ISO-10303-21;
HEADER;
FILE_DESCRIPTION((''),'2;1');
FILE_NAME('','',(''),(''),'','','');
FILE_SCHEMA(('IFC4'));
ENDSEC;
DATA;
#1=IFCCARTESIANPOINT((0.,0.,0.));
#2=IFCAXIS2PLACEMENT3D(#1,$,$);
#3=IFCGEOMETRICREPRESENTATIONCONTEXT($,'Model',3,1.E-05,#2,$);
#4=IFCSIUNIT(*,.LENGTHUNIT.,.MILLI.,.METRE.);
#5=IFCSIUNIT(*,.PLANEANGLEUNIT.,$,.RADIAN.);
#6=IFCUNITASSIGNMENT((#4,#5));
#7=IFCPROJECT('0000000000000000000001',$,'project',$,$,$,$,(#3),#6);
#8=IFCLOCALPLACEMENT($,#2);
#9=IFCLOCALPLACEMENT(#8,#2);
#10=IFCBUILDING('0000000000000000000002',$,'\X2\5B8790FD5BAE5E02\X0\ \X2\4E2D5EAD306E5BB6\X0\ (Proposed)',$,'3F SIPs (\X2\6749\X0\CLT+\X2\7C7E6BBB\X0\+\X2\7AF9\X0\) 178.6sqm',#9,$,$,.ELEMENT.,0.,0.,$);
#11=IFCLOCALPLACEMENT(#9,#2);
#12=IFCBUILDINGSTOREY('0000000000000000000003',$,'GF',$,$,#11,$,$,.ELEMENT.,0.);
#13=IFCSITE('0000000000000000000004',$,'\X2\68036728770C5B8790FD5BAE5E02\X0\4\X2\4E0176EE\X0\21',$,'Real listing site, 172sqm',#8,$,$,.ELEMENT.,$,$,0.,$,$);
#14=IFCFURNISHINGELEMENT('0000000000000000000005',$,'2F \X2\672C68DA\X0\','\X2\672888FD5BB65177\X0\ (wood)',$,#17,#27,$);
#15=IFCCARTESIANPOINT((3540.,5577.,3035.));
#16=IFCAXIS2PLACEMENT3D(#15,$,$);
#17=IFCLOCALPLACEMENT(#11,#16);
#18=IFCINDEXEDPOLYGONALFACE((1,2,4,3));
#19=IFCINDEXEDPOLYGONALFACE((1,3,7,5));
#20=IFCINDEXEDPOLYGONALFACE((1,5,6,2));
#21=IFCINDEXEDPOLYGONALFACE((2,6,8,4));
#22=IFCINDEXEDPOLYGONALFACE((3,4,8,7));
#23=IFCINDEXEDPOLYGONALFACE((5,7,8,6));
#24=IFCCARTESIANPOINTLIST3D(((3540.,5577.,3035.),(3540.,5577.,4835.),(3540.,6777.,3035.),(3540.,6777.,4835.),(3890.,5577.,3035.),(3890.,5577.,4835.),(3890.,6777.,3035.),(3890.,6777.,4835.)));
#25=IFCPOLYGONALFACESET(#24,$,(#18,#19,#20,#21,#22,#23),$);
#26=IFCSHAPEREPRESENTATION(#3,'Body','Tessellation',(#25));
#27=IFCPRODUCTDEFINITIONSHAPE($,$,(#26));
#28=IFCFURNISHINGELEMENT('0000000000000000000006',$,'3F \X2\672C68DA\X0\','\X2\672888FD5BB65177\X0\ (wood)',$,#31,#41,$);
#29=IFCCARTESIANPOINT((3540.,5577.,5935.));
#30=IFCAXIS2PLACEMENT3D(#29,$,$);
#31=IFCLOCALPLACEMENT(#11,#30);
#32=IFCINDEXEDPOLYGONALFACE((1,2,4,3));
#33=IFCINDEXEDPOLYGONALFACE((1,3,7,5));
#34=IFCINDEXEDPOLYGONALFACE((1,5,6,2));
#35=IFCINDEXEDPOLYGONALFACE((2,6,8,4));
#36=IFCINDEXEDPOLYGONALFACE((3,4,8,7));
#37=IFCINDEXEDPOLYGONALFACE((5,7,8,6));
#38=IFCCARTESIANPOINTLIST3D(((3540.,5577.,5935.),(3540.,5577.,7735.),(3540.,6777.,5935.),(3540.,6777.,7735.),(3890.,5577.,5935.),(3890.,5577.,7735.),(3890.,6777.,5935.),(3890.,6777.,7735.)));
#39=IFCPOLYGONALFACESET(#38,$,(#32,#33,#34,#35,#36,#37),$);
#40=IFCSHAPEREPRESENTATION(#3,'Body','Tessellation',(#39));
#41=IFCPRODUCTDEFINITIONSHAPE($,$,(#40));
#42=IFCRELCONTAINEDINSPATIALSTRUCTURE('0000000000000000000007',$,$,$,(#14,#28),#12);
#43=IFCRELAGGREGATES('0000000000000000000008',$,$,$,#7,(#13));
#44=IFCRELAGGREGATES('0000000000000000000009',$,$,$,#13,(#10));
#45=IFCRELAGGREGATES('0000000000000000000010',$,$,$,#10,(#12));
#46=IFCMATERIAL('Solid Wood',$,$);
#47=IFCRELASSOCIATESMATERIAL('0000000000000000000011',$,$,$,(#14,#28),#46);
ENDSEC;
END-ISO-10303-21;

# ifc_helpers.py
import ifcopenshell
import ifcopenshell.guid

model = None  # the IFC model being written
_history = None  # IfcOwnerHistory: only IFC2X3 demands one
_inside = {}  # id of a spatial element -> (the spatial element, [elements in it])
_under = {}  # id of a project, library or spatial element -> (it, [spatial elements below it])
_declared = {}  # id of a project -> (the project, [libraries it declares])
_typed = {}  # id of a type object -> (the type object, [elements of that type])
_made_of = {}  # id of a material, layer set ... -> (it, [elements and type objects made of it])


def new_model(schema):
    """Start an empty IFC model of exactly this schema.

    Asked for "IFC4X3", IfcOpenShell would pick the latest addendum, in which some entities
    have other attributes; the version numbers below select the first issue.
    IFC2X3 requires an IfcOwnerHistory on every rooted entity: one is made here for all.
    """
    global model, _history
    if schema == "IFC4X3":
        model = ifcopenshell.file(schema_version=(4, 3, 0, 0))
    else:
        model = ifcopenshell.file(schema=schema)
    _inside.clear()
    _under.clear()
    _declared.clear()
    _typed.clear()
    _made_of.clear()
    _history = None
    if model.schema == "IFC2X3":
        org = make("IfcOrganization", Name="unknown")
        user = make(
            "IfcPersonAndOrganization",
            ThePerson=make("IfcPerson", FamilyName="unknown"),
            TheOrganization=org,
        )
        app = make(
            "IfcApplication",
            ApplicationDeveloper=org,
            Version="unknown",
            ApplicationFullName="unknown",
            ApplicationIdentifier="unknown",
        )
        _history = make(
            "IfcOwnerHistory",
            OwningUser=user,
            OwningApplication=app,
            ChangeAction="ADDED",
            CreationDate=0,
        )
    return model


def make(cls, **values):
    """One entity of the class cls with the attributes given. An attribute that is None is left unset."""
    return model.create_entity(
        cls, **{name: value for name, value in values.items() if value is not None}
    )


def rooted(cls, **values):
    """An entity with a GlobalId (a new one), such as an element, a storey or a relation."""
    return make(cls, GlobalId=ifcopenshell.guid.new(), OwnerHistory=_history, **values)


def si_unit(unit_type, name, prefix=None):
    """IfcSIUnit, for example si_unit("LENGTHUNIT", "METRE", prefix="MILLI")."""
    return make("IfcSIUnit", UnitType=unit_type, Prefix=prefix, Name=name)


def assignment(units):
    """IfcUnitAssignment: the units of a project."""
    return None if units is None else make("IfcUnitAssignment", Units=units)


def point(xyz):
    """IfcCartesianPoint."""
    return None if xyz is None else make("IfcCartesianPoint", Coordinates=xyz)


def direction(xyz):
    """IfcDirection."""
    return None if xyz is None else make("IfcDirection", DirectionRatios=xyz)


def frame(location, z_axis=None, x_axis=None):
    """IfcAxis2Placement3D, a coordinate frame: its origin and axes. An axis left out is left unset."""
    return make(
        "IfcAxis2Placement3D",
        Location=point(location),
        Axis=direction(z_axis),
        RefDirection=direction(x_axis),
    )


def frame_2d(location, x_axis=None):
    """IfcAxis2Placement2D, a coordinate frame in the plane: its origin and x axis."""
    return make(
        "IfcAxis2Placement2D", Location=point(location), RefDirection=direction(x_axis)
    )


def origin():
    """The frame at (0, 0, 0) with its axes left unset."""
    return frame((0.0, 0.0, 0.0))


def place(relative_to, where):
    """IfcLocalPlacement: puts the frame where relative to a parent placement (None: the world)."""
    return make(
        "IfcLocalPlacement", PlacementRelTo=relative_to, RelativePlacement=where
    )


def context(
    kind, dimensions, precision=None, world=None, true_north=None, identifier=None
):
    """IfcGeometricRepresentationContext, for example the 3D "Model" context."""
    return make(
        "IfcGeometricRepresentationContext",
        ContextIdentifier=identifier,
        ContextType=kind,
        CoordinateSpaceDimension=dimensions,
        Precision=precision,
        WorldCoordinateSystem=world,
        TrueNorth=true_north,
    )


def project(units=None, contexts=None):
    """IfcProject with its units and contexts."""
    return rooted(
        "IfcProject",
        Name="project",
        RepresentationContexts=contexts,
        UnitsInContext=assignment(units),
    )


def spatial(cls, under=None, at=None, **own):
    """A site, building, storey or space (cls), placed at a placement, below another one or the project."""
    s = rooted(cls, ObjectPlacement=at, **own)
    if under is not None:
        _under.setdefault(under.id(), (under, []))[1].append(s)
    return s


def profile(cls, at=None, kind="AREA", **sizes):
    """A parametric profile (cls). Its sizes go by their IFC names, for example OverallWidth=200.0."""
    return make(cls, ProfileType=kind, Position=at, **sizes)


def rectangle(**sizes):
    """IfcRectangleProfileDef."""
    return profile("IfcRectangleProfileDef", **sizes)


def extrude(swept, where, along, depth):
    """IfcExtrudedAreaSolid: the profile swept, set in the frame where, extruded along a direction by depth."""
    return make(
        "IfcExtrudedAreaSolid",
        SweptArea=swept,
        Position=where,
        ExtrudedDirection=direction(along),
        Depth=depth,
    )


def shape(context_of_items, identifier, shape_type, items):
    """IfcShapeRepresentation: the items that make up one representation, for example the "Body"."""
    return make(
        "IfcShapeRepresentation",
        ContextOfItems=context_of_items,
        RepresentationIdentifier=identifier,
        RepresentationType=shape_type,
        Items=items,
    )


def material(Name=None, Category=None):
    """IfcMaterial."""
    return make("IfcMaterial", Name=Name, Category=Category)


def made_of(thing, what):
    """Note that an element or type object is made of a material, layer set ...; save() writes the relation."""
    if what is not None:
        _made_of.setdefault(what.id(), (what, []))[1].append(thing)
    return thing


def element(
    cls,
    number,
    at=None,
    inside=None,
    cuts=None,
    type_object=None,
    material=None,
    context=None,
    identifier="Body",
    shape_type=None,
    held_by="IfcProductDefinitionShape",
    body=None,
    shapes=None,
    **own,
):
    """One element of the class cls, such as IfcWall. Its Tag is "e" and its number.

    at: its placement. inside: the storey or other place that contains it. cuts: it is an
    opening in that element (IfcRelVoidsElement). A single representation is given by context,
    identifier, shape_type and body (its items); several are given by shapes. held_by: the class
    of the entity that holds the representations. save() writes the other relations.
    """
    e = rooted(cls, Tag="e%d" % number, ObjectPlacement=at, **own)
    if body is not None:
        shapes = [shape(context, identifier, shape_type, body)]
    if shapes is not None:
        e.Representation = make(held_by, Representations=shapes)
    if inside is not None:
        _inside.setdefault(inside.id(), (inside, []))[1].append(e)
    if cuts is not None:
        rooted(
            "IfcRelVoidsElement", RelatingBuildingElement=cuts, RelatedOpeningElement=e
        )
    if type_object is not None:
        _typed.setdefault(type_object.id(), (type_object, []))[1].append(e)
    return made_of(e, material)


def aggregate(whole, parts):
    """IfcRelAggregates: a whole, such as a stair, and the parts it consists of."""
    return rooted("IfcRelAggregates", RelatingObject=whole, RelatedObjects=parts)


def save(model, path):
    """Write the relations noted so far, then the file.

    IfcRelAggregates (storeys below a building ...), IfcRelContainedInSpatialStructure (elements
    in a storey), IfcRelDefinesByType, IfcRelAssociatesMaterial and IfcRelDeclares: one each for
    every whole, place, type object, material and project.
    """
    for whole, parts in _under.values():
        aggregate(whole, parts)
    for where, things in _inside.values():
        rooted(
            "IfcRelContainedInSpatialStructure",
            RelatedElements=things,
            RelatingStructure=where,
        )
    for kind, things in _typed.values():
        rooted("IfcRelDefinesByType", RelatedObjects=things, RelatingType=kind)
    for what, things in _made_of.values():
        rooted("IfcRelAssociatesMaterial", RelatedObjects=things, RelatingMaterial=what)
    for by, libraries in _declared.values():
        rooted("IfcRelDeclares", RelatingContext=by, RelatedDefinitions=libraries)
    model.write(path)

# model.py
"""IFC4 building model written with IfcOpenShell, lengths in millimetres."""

from ifc_helpers import new_model, si_unit, frame, frame_2d, origin, place, context, project, spatial, rectangle, extrude, material, element, save


model = new_model("IFC4")

# Units and contexts
model_context = context("Model", 3, precision=1e-05, world=origin())
ifc_project = project(units=[si_unit("LENGTHUNIT", "METRE", prefix="MILLI"), si_unit("PLANEANGLEUNIT", "RADIAN")], contexts=[model_context])

# Site, building, storey
site_placement = place(None, origin())
site = spatial("IfcSite", under=ifc_project, at=site_placement, Name="栃木県宇都宮市4丁目21", ObjectType="Real listing site, 172sqm", CompositionType="ELEMENT", RefElevation=0.0)
building_placement = place(site_placement, origin())
building = spatial("IfcBuilding", under=site, at=building_placement, Name="宇都宮市 中庭の家 (Proposed)", ObjectType="3F SIPs (杉CLT+籾殻+竹) 178.6sqm", CompositionType="ELEMENT", ElevationOfRefHeight=0.0, ElevationOfTerrain=0.0)
storey_placement = place(building_placement, origin())
storey = spatial("IfcBuildingStorey", under=building, at=storey_placement, Name="GF", CompositionType="ELEMENT", Elevation=0.0)

# Shared definitions
ifc_material_1 = material(Name="Solid Wood")

# Furnishing elements
furnishing_1_placement = place(storey_placement, frame((3540.0, 5577.0, 3035.0)))
element("IfcFurnishingElement", 1, at=furnishing_1_placement, inside=storey, material=ifc_material_1, Name="2F 本棚", Description="木製家具 (wood)", context=model_context, shape_type="SweptSolid", body=[
    extrude(rectangle(XDim=350.0, YDim=1200.0, at=frame_2d((175.0, 600.0))), frame((3540.0, 5577.0, 3035.0)), (0.0, 0.0, 1.0), 1800.0),
])
furnishing_2_placement = place(storey_placement, frame((3540.0, 5577.0, 5935.0)))
element("IfcFurnishingElement", 2, at=furnishing_2_placement, inside=storey, material=ifc_material_1, Name="3F 本棚", Description="木製家具 (wood)", context=model_context, shape_type="SweptSolid", body=[
    extrude(rectangle(XDim=350.0, YDim=1200.0, at=frame_2d((175.0, 600.0))), frame((3540.0, 5577.0, 5935.0)), (0.0, 0.0, 1.0), 1800.0),
])

save(model, "model.ifc")
